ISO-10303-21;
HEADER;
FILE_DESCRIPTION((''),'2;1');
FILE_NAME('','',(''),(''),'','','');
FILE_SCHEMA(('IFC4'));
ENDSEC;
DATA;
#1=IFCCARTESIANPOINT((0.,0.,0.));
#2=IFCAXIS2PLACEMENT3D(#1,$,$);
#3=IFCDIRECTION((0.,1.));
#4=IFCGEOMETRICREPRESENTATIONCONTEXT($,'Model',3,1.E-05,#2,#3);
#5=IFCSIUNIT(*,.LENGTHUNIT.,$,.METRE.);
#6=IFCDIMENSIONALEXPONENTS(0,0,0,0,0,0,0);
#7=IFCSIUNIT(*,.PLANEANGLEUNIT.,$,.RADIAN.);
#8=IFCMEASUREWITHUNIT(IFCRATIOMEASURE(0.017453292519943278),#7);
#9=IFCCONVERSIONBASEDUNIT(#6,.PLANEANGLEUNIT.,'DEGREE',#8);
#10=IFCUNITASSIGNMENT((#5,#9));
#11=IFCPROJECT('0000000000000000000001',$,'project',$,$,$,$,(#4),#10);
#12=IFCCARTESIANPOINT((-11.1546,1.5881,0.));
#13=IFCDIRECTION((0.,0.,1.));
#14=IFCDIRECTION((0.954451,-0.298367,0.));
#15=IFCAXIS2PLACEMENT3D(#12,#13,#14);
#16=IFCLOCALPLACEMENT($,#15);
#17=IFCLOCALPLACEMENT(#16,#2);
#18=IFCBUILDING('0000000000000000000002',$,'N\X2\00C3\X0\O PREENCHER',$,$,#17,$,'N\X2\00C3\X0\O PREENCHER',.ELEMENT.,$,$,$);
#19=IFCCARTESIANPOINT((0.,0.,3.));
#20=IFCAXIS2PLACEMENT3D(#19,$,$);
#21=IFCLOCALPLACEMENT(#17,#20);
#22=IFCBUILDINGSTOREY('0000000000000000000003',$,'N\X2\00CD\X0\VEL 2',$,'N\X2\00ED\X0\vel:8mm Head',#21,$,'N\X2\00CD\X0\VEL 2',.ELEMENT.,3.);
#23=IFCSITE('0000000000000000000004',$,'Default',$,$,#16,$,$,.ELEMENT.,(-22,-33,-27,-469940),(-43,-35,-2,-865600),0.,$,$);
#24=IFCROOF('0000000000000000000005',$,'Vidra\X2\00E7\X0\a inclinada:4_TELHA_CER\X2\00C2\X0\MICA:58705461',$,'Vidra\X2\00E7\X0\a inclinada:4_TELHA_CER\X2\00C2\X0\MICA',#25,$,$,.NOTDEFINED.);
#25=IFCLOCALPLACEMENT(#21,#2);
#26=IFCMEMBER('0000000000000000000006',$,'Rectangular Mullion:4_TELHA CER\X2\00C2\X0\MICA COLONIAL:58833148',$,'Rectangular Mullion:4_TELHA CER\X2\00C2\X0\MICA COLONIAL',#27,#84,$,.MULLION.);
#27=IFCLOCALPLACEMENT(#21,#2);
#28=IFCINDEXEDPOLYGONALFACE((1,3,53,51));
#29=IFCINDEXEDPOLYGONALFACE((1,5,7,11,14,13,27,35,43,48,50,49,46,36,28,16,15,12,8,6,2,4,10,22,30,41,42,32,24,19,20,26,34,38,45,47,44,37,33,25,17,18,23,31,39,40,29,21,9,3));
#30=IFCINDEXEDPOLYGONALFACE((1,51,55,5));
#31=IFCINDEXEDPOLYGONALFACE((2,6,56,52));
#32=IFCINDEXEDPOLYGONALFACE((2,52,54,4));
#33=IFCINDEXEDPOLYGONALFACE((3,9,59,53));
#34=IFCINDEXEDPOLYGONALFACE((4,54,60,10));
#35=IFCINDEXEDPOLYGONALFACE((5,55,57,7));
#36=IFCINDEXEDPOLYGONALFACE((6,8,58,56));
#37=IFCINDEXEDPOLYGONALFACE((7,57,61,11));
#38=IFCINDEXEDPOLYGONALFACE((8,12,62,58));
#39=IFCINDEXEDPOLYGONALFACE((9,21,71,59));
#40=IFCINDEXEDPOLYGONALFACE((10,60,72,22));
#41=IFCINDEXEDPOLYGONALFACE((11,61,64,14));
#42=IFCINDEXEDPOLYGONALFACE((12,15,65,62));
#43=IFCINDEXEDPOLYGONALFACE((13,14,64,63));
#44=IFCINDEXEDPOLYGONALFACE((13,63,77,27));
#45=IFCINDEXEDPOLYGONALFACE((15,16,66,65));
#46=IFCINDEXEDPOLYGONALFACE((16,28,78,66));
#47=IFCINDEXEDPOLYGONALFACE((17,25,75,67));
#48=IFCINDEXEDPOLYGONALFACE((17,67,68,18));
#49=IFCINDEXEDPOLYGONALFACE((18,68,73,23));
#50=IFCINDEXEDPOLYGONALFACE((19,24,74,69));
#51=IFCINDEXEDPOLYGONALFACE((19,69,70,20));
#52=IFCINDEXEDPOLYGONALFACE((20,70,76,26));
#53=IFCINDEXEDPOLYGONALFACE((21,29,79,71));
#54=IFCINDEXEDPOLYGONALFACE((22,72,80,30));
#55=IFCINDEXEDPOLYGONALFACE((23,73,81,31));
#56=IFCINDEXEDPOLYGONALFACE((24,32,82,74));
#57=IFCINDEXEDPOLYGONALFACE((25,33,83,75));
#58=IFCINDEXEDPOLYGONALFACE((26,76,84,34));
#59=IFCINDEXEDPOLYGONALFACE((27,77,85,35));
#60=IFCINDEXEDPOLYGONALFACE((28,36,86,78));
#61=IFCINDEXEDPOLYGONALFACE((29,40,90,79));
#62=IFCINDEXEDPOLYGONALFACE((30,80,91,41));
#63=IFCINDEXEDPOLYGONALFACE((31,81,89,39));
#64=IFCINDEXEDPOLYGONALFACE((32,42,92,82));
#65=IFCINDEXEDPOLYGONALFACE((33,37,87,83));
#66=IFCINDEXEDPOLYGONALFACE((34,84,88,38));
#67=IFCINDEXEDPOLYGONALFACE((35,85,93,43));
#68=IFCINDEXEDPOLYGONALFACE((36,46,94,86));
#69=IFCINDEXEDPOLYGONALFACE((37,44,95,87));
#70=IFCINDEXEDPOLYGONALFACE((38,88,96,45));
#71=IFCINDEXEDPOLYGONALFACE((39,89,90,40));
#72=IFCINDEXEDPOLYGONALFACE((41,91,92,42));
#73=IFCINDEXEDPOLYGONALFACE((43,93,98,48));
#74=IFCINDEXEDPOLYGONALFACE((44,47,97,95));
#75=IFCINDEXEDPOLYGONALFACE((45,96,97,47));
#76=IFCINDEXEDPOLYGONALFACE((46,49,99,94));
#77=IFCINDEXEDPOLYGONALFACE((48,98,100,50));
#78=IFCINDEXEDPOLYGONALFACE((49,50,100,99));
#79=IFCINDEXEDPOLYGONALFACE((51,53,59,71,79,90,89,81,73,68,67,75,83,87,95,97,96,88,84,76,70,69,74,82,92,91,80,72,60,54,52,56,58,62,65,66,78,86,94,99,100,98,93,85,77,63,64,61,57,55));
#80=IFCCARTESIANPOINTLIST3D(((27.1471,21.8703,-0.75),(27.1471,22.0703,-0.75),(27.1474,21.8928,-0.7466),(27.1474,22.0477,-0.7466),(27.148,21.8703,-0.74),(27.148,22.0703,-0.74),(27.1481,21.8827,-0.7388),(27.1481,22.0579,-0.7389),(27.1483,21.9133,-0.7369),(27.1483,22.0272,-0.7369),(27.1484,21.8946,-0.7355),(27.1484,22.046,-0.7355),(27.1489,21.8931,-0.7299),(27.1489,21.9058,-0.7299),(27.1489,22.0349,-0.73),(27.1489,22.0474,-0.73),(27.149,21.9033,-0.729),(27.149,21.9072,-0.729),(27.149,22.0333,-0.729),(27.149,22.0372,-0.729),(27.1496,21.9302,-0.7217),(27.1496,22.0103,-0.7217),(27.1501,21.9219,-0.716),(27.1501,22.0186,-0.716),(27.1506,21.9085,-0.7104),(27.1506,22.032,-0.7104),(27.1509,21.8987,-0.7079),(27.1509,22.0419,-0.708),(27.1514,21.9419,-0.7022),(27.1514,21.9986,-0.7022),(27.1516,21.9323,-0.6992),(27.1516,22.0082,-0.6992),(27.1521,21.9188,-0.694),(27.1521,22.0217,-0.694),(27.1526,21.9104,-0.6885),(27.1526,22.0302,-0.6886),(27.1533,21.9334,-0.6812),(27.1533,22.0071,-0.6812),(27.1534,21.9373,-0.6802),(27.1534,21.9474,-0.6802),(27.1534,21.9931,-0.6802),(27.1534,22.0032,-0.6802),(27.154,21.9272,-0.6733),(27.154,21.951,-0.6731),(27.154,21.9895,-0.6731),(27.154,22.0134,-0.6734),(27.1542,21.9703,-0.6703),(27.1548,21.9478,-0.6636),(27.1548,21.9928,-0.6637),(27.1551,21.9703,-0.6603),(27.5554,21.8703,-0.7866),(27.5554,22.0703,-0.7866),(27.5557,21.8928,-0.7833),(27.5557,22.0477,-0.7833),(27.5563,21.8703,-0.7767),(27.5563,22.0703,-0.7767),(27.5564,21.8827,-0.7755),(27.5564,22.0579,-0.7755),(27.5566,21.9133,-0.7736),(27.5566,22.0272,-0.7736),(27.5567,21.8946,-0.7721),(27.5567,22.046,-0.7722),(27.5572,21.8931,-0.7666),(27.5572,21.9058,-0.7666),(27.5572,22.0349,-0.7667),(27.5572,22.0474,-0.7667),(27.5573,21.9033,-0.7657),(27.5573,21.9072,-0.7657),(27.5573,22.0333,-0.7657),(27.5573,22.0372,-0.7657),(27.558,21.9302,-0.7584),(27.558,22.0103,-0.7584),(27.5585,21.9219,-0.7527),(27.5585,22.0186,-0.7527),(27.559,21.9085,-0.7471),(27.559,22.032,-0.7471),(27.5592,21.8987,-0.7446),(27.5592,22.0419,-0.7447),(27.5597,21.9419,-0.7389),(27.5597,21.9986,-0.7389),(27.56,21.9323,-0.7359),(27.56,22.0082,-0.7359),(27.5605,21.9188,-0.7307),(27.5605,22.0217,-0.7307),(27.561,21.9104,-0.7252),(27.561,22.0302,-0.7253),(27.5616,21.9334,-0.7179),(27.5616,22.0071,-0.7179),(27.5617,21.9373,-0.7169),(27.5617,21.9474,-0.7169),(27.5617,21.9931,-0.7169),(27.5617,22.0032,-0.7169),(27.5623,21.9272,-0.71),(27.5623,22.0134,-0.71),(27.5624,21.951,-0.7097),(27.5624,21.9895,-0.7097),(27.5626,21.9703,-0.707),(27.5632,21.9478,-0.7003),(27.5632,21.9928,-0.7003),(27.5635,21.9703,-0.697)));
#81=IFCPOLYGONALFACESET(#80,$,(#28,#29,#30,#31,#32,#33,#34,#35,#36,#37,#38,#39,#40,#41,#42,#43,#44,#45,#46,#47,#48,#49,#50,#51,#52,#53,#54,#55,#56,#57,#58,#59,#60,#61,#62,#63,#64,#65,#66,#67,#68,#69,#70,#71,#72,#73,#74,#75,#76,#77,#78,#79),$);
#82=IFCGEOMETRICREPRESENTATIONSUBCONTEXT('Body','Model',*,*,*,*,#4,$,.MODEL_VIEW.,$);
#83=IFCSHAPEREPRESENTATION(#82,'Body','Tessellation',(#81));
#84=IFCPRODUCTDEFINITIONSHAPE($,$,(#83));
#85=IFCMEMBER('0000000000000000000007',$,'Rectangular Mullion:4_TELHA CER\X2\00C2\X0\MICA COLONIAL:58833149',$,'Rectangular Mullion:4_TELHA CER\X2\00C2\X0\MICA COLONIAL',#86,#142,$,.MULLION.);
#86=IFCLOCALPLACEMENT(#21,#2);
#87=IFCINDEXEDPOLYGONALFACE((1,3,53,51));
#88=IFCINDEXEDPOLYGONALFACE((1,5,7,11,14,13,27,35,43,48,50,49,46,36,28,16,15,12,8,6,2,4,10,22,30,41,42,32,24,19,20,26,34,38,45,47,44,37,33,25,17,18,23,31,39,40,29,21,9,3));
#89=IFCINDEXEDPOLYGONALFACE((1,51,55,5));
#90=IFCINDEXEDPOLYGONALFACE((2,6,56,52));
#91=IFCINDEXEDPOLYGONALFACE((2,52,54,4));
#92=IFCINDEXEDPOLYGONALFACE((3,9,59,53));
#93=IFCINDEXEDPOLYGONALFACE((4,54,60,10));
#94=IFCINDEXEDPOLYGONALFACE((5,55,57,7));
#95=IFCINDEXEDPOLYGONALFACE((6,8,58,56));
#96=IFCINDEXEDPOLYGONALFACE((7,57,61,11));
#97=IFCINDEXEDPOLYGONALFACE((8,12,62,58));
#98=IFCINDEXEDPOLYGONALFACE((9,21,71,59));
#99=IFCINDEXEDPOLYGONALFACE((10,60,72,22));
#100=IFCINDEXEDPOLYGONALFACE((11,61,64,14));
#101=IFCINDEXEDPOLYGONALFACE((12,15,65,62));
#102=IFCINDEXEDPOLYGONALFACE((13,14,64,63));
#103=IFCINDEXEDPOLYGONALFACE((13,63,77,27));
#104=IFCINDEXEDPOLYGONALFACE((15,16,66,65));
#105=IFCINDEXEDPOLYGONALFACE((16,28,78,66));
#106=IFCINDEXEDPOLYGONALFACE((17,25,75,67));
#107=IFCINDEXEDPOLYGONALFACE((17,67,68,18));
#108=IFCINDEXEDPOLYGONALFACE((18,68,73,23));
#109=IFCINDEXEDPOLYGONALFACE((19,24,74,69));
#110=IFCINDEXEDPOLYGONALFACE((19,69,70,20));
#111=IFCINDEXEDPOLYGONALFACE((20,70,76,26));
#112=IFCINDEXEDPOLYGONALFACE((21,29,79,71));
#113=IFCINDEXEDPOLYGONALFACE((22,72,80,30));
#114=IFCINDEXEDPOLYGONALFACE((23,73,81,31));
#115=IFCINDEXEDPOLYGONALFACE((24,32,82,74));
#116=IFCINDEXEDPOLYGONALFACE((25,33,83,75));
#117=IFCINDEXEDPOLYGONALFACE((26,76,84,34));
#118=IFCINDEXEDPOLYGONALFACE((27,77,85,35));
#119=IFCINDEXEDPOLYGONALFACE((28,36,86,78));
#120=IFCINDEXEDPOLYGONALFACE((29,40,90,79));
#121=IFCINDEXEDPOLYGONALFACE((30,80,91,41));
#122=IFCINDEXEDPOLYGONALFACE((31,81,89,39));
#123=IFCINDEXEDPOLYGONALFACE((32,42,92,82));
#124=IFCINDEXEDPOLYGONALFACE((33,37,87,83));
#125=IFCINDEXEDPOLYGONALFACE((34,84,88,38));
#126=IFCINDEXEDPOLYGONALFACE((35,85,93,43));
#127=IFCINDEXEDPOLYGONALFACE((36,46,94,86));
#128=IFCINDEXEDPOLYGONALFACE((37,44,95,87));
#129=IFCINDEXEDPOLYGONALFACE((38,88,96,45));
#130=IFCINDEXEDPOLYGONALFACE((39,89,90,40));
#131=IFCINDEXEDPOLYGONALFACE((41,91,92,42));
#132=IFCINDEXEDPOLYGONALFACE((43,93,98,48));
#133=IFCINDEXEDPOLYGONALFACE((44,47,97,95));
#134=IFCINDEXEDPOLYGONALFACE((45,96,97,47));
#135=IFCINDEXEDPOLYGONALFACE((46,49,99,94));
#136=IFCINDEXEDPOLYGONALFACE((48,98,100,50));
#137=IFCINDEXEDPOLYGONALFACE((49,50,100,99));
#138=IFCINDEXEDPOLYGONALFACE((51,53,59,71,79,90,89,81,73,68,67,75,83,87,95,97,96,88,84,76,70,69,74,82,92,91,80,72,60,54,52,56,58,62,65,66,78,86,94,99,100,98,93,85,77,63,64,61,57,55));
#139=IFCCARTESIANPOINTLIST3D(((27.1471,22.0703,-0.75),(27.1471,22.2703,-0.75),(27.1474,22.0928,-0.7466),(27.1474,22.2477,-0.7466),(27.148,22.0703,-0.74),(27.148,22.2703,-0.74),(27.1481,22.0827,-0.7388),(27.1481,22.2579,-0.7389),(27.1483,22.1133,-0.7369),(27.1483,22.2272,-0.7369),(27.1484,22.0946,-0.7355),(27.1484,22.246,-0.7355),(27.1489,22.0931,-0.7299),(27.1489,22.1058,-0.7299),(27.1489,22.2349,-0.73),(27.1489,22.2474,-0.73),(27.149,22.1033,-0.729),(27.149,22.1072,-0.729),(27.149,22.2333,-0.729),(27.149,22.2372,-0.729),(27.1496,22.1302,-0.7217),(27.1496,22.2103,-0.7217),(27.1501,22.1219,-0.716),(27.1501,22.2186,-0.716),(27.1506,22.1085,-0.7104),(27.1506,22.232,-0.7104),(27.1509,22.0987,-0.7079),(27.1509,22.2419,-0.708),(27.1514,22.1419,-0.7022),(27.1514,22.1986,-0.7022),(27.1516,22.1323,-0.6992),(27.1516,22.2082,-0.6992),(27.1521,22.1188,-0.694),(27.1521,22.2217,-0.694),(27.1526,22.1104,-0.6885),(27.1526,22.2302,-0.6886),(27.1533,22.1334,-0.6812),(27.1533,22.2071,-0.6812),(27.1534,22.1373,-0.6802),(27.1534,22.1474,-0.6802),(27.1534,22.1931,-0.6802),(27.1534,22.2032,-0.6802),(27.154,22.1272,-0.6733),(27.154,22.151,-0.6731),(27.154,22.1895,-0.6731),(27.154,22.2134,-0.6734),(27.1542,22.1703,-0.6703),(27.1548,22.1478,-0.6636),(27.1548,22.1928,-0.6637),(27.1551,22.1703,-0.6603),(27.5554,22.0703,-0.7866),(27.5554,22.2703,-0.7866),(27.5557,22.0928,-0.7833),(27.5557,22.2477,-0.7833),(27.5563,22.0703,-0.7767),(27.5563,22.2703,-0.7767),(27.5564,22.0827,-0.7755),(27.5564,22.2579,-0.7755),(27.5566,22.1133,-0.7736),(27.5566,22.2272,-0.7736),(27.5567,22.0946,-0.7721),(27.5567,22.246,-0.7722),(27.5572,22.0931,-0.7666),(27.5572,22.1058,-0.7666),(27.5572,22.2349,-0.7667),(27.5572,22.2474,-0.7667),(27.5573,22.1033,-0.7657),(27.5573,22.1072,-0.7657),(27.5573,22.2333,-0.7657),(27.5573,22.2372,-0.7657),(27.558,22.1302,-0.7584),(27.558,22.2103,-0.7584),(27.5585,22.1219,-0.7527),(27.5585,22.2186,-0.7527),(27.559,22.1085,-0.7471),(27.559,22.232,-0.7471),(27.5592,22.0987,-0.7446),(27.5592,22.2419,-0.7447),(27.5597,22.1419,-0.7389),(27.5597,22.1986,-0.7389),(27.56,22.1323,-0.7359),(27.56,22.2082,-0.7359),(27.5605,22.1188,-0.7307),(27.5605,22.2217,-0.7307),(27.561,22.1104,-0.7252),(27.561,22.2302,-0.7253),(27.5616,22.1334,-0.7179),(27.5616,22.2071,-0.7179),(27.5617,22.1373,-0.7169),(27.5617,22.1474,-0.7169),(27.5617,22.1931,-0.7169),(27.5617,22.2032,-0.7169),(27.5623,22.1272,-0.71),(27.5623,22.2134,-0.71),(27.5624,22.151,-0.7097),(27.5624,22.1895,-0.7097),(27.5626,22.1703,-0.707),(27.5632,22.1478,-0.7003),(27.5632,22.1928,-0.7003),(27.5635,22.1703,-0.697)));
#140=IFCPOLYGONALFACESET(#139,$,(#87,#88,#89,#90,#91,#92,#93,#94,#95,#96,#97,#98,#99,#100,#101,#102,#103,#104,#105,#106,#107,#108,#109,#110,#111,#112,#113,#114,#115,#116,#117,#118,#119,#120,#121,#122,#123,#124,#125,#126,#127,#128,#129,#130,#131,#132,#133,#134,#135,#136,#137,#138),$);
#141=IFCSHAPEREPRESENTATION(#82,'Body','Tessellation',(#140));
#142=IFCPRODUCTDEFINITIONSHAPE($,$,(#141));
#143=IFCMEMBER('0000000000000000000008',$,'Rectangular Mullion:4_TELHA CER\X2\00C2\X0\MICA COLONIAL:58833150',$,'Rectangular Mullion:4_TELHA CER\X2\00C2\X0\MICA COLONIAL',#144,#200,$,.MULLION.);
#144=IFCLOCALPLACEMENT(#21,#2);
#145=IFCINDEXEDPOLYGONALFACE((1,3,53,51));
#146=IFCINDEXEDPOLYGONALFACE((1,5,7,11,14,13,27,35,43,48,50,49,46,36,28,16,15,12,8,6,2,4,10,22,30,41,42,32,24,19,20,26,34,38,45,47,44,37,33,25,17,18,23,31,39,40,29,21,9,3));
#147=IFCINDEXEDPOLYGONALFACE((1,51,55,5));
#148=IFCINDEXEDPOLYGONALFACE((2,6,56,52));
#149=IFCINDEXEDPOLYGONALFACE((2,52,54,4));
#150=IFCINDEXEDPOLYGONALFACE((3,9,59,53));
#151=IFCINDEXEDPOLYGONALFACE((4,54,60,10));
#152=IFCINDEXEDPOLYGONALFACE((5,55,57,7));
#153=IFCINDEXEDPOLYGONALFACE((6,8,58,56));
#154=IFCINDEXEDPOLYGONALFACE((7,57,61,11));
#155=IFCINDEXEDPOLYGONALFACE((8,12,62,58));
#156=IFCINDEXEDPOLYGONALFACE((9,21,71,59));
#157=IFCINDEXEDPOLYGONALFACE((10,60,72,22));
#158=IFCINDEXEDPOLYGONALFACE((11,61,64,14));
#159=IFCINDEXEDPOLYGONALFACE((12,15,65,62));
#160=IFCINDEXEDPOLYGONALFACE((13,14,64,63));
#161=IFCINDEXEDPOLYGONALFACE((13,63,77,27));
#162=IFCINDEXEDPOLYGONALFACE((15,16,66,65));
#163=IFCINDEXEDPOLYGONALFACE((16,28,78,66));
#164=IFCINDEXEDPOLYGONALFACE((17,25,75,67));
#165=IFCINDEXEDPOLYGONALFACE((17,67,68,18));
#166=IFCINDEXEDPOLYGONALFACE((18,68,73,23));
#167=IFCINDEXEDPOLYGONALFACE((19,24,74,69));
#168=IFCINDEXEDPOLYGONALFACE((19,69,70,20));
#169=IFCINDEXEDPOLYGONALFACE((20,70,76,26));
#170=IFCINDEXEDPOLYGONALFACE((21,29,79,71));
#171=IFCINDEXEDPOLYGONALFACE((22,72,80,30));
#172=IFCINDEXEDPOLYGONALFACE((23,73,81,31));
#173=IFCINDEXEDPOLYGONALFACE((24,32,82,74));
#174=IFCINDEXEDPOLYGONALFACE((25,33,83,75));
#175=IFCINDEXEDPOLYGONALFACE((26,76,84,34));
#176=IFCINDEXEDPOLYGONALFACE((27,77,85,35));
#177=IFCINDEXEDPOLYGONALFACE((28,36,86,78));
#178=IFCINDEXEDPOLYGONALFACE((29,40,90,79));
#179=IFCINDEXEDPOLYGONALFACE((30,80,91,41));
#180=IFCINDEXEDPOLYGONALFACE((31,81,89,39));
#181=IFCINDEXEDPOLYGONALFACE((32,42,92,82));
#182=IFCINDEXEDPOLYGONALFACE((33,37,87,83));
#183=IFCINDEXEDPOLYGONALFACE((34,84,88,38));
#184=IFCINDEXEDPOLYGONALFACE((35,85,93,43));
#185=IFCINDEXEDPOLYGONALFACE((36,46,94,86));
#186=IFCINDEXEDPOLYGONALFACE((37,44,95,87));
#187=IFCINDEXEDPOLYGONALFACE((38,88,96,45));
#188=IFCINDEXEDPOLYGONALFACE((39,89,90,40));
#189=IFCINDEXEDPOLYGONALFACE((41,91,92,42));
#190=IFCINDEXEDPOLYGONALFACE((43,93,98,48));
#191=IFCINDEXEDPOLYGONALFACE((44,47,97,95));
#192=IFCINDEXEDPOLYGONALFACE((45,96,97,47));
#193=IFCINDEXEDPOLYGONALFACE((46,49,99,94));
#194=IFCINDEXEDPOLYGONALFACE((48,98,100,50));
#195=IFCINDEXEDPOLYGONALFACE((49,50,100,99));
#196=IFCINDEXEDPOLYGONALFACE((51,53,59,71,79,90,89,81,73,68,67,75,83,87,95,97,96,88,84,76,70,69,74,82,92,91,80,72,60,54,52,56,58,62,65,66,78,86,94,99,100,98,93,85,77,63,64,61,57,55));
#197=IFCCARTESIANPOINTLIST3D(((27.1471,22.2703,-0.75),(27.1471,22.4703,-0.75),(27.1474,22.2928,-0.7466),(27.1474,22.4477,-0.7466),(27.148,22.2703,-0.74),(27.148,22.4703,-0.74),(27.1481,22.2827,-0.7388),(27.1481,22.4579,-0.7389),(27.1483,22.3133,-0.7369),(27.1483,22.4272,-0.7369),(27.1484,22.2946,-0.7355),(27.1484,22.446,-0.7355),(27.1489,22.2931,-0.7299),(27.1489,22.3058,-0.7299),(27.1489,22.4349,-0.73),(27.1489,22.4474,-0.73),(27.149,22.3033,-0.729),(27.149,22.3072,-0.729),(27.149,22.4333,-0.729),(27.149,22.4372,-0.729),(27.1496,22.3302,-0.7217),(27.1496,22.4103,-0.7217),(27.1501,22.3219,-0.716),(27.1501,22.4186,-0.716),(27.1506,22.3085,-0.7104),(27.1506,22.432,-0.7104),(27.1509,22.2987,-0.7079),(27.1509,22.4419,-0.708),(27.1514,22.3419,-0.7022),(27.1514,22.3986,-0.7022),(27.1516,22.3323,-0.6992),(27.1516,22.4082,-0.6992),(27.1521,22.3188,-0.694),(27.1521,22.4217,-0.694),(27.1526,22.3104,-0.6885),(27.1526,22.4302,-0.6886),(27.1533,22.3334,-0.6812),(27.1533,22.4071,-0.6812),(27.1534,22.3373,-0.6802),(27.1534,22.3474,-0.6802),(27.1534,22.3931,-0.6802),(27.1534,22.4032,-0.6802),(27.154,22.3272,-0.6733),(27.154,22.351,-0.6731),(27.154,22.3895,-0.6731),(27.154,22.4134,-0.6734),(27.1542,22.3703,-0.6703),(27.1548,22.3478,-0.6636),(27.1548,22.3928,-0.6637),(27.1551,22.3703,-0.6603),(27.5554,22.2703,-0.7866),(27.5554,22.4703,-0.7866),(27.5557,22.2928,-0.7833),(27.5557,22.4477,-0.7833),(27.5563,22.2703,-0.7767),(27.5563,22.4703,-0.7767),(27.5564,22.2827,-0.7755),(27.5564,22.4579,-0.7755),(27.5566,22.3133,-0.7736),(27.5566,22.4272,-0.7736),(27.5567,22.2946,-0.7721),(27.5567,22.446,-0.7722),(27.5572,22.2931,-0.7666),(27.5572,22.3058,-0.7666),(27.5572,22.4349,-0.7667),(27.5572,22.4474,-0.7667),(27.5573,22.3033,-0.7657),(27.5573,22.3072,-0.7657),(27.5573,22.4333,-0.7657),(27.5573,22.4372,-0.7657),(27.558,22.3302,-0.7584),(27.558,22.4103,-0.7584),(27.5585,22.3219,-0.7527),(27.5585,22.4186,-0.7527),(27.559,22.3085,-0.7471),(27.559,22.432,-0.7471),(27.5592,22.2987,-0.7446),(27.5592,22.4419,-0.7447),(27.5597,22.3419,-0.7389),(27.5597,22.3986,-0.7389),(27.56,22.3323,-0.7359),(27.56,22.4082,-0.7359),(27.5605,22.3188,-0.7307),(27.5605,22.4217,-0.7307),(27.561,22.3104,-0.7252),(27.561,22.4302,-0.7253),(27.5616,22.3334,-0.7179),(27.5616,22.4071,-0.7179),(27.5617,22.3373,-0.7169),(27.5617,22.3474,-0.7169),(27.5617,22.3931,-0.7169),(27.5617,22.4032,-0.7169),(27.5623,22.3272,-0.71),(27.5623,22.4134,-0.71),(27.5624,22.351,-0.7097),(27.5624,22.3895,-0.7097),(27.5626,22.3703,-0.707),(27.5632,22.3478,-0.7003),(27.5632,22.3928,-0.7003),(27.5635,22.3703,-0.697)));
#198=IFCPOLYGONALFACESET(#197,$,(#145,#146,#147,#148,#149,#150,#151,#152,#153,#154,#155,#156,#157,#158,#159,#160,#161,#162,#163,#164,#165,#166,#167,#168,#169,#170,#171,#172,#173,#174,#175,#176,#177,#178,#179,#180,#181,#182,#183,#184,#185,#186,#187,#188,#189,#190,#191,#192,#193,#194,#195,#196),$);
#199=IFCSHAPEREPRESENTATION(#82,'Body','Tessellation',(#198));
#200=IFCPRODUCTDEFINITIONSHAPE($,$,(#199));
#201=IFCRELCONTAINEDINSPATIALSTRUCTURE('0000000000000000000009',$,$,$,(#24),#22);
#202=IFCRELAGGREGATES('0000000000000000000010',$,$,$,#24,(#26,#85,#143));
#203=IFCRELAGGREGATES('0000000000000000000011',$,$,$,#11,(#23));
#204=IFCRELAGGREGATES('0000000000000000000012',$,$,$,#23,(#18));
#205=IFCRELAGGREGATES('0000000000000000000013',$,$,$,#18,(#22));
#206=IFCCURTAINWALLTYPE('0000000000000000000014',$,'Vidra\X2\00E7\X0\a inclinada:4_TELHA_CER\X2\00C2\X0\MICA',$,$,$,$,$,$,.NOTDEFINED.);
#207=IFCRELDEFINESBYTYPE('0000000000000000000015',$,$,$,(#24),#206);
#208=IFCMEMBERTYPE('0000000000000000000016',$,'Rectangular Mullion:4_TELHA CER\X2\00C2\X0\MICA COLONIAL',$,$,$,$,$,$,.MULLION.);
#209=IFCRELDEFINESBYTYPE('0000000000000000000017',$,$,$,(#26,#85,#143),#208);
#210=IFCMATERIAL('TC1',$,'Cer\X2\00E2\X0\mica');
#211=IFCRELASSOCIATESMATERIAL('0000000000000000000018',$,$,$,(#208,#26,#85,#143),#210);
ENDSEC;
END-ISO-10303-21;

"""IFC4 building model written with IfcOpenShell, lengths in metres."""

from ifc_helpers import new_model, entity, si_unit, converted_unit, direction, frame, origin, place, context, subcontext, project, spatial, line, arc, indexed_curve, outline, extrude, source, transform, mapped, material, type_object, type_shapes, element, aggregate, save


model = new_model("IFC4")

# Units and contexts
model_context = context("Model", 3, precision=1e-05, world=origin(), true_north=direction((0.0, 1.0)))
body_context = subcontext(model_context, "Body", "Model", "MODEL_VIEW")
ifc_project = project(units=[si_unit("LENGTHUNIT", "METRE"), converted_unit("PLANEANGLEUNIT", "DEGREE", entity("IfcRatioMeasure", 0.017453292519943278), si_unit("PLANEANGLEUNIT", "RADIAN"), dimensions=[0, 0, 0, 0, 0, 0, 0])], contexts=[model_context])

# Site, building, storey
site_placement = place(None, frame((-11.1546, 1.5881, 0.0), z_axis=(0.0, 0.0, 1.0), x_axis=(0.954451, -0.298367, 0.0)))
site = spatial("IfcSite", under=ifc_project, at=site_placement, Name="Default", CompositionType="ELEMENT", RefLatitude=(-22, -33, -27, -469940), RefLongitude=(-43, -35, -2, -865600), RefElevation=0.0)
building_placement = place(site_placement, origin())
building = spatial("IfcBuilding", under=site, at=building_placement, Name="NÃO PREENCHER", LongName="NÃO PREENCHER", CompositionType="ELEMENT")
storey_placement = place(building_placement, frame((0.0, 0.0, 3.0)))
storey = spatial("IfcBuildingStorey", under=building, at=storey_placement, Name="NÍVEL 2", ObjectType="Nível:8mm Head", LongName="NÍVEL 2", CompositionType="ELEMENT", Elevation=3.0)

# Roof, members
curtain_wall_type = type_object("IfcCurtainWallType", Name="Vidraça inclinada:4_TELHA_CERÂMICA", PredefinedType="NOTDEFINED")
roof_placement = place(storey_placement, frame((0.0, 0.0, -3.0)))
roof = element("IfcRoof", 1, at=roof_placement, inside=storey, type_object=curtain_wall_type, Name="Vidraça inclinada:4_TELHA_CERÂMICA:58705461", ObjectType="Vidraça inclinada:4_TELHA_CERÂMICA", PredefinedType="NOTDEFINED")
ifc_material = material(Name="TC1", Category="Cerâmica")
member_type_1 = type_object("IfcMemberType", Name="Rectangular Mullion:4_TELHA CERÂMICA COLONIAL", PredefinedType="MULLION", material=ifc_material)
shared_shape_1 = source(origin(), body_context, "Body", "SweptSolid", [
    extrude(outline(indexed_curve([(-0.029, -0.1), (-0.019, -0.1), (-0.0164, -0.0815), (-0.0089, -0.0645), (-0.0089, -0.0771), (0.061, 0.0), (-0.009, 0.0771), (-0.009, 0.0646), (-0.0165, 0.0816), (-0.019, 0.1), (-0.029, 0.1), (-0.0089, 0.0479), (0.041, 0.0229), (0.041, 0.0329), (0.0131, 0.0425), (-0.008, 0.0631), (-0.008, 0.067), (0.051, 0.0), (-0.008, -0.067), (-0.008, -0.0631), (0.0131, -0.0425), (0.041, -0.0329), (0.041, -0.0229), (-0.0089, -0.0479)], segments=[line(1, 2), arc(2, 3, 4), line(4, 5), arc(5, 6, 7), line(7, 8), arc(8, 9, 10), line(10, 11), arc(11, 12, 13), line(13, 14), arc(14, 15, 16), line(16, 17), arc(17, 18, 19), line(19, 20), arc(20, 21, 22), line(22, 23), arc(23, 24, 1)], self_intersect=False)), frame((0.0, -0.029, -0.41), z_axis=(0.0, 0.0, 1.0), x_axis=(0.0, -1.0, 0.0)), (0.0, 0.0, 1.0), 0.41),
])
type_shapes(member_type_1, [shared_shape_1])
member_1_placement = place(roof_placement, frame((27.1471, 21.9703, 2.25), z_axis=(-0.99599, 0.0, 0.089469), x_axis=(0.0, 1.0, 0.0)))
member_1 = element("IfcMember", 2, at=member_1_placement, type_object=member_type_1, material=ifc_material, Name="Rectangular Mullion:4_TELHA CERÂMICA COLONIAL:58833148", ObjectType="Rectangular Mullion:4_TELHA CERÂMICA COLONIAL", PredefinedType="MULLION", context=body_context, shape_type="MappedRepresentation", body=[
    mapped(shared_shape_1, transform((0.0, 0.0, 0.0), scale=1.0)),
])
member_2_placement = place(roof_placement, frame((27.1471, 22.1703, 2.25), z_axis=(-0.99599, 0.0, 0.089469), x_axis=(0.0, 1.0, 0.0)))
member_2 = element("IfcMember", 3, at=member_2_placement, type_object=member_type_1, material=ifc_material, Name="Rectangular Mullion:4_TELHA CERÂMICA COLONIAL:58833149", ObjectType="Rectangular Mullion:4_TELHA CERÂMICA COLONIAL", PredefinedType="MULLION", context=body_context, shape_type="MappedRepresentation", body=[
    mapped(shared_shape_1, transform((0.0, 0.0, 0.0), scale=1.0)),
])
member_3_placement = place(roof_placement, frame((27.1471, 22.3703, 2.25), z_axis=(-0.99599, 0.0, 0.089469), x_axis=(0.0, 1.0, 0.0)))
member_3 = element("IfcMember", 4, at=member_3_placement, type_object=member_type_1, material=ifc_material, Name="Rectangular Mullion:4_TELHA CERÂMICA COLONIAL:58833150", ObjectType="Rectangular Mullion:4_TELHA CERÂMICA COLONIAL", PredefinedType="MULLION", context=body_context, shape_type="MappedRepresentation", body=[
    mapped(shared_shape_1, transform((0.0, 0.0, 0.0), scale=1.0)),
])
aggregate(roof, [member_1, member_2, member_3])

save(model, "model.ifc")
